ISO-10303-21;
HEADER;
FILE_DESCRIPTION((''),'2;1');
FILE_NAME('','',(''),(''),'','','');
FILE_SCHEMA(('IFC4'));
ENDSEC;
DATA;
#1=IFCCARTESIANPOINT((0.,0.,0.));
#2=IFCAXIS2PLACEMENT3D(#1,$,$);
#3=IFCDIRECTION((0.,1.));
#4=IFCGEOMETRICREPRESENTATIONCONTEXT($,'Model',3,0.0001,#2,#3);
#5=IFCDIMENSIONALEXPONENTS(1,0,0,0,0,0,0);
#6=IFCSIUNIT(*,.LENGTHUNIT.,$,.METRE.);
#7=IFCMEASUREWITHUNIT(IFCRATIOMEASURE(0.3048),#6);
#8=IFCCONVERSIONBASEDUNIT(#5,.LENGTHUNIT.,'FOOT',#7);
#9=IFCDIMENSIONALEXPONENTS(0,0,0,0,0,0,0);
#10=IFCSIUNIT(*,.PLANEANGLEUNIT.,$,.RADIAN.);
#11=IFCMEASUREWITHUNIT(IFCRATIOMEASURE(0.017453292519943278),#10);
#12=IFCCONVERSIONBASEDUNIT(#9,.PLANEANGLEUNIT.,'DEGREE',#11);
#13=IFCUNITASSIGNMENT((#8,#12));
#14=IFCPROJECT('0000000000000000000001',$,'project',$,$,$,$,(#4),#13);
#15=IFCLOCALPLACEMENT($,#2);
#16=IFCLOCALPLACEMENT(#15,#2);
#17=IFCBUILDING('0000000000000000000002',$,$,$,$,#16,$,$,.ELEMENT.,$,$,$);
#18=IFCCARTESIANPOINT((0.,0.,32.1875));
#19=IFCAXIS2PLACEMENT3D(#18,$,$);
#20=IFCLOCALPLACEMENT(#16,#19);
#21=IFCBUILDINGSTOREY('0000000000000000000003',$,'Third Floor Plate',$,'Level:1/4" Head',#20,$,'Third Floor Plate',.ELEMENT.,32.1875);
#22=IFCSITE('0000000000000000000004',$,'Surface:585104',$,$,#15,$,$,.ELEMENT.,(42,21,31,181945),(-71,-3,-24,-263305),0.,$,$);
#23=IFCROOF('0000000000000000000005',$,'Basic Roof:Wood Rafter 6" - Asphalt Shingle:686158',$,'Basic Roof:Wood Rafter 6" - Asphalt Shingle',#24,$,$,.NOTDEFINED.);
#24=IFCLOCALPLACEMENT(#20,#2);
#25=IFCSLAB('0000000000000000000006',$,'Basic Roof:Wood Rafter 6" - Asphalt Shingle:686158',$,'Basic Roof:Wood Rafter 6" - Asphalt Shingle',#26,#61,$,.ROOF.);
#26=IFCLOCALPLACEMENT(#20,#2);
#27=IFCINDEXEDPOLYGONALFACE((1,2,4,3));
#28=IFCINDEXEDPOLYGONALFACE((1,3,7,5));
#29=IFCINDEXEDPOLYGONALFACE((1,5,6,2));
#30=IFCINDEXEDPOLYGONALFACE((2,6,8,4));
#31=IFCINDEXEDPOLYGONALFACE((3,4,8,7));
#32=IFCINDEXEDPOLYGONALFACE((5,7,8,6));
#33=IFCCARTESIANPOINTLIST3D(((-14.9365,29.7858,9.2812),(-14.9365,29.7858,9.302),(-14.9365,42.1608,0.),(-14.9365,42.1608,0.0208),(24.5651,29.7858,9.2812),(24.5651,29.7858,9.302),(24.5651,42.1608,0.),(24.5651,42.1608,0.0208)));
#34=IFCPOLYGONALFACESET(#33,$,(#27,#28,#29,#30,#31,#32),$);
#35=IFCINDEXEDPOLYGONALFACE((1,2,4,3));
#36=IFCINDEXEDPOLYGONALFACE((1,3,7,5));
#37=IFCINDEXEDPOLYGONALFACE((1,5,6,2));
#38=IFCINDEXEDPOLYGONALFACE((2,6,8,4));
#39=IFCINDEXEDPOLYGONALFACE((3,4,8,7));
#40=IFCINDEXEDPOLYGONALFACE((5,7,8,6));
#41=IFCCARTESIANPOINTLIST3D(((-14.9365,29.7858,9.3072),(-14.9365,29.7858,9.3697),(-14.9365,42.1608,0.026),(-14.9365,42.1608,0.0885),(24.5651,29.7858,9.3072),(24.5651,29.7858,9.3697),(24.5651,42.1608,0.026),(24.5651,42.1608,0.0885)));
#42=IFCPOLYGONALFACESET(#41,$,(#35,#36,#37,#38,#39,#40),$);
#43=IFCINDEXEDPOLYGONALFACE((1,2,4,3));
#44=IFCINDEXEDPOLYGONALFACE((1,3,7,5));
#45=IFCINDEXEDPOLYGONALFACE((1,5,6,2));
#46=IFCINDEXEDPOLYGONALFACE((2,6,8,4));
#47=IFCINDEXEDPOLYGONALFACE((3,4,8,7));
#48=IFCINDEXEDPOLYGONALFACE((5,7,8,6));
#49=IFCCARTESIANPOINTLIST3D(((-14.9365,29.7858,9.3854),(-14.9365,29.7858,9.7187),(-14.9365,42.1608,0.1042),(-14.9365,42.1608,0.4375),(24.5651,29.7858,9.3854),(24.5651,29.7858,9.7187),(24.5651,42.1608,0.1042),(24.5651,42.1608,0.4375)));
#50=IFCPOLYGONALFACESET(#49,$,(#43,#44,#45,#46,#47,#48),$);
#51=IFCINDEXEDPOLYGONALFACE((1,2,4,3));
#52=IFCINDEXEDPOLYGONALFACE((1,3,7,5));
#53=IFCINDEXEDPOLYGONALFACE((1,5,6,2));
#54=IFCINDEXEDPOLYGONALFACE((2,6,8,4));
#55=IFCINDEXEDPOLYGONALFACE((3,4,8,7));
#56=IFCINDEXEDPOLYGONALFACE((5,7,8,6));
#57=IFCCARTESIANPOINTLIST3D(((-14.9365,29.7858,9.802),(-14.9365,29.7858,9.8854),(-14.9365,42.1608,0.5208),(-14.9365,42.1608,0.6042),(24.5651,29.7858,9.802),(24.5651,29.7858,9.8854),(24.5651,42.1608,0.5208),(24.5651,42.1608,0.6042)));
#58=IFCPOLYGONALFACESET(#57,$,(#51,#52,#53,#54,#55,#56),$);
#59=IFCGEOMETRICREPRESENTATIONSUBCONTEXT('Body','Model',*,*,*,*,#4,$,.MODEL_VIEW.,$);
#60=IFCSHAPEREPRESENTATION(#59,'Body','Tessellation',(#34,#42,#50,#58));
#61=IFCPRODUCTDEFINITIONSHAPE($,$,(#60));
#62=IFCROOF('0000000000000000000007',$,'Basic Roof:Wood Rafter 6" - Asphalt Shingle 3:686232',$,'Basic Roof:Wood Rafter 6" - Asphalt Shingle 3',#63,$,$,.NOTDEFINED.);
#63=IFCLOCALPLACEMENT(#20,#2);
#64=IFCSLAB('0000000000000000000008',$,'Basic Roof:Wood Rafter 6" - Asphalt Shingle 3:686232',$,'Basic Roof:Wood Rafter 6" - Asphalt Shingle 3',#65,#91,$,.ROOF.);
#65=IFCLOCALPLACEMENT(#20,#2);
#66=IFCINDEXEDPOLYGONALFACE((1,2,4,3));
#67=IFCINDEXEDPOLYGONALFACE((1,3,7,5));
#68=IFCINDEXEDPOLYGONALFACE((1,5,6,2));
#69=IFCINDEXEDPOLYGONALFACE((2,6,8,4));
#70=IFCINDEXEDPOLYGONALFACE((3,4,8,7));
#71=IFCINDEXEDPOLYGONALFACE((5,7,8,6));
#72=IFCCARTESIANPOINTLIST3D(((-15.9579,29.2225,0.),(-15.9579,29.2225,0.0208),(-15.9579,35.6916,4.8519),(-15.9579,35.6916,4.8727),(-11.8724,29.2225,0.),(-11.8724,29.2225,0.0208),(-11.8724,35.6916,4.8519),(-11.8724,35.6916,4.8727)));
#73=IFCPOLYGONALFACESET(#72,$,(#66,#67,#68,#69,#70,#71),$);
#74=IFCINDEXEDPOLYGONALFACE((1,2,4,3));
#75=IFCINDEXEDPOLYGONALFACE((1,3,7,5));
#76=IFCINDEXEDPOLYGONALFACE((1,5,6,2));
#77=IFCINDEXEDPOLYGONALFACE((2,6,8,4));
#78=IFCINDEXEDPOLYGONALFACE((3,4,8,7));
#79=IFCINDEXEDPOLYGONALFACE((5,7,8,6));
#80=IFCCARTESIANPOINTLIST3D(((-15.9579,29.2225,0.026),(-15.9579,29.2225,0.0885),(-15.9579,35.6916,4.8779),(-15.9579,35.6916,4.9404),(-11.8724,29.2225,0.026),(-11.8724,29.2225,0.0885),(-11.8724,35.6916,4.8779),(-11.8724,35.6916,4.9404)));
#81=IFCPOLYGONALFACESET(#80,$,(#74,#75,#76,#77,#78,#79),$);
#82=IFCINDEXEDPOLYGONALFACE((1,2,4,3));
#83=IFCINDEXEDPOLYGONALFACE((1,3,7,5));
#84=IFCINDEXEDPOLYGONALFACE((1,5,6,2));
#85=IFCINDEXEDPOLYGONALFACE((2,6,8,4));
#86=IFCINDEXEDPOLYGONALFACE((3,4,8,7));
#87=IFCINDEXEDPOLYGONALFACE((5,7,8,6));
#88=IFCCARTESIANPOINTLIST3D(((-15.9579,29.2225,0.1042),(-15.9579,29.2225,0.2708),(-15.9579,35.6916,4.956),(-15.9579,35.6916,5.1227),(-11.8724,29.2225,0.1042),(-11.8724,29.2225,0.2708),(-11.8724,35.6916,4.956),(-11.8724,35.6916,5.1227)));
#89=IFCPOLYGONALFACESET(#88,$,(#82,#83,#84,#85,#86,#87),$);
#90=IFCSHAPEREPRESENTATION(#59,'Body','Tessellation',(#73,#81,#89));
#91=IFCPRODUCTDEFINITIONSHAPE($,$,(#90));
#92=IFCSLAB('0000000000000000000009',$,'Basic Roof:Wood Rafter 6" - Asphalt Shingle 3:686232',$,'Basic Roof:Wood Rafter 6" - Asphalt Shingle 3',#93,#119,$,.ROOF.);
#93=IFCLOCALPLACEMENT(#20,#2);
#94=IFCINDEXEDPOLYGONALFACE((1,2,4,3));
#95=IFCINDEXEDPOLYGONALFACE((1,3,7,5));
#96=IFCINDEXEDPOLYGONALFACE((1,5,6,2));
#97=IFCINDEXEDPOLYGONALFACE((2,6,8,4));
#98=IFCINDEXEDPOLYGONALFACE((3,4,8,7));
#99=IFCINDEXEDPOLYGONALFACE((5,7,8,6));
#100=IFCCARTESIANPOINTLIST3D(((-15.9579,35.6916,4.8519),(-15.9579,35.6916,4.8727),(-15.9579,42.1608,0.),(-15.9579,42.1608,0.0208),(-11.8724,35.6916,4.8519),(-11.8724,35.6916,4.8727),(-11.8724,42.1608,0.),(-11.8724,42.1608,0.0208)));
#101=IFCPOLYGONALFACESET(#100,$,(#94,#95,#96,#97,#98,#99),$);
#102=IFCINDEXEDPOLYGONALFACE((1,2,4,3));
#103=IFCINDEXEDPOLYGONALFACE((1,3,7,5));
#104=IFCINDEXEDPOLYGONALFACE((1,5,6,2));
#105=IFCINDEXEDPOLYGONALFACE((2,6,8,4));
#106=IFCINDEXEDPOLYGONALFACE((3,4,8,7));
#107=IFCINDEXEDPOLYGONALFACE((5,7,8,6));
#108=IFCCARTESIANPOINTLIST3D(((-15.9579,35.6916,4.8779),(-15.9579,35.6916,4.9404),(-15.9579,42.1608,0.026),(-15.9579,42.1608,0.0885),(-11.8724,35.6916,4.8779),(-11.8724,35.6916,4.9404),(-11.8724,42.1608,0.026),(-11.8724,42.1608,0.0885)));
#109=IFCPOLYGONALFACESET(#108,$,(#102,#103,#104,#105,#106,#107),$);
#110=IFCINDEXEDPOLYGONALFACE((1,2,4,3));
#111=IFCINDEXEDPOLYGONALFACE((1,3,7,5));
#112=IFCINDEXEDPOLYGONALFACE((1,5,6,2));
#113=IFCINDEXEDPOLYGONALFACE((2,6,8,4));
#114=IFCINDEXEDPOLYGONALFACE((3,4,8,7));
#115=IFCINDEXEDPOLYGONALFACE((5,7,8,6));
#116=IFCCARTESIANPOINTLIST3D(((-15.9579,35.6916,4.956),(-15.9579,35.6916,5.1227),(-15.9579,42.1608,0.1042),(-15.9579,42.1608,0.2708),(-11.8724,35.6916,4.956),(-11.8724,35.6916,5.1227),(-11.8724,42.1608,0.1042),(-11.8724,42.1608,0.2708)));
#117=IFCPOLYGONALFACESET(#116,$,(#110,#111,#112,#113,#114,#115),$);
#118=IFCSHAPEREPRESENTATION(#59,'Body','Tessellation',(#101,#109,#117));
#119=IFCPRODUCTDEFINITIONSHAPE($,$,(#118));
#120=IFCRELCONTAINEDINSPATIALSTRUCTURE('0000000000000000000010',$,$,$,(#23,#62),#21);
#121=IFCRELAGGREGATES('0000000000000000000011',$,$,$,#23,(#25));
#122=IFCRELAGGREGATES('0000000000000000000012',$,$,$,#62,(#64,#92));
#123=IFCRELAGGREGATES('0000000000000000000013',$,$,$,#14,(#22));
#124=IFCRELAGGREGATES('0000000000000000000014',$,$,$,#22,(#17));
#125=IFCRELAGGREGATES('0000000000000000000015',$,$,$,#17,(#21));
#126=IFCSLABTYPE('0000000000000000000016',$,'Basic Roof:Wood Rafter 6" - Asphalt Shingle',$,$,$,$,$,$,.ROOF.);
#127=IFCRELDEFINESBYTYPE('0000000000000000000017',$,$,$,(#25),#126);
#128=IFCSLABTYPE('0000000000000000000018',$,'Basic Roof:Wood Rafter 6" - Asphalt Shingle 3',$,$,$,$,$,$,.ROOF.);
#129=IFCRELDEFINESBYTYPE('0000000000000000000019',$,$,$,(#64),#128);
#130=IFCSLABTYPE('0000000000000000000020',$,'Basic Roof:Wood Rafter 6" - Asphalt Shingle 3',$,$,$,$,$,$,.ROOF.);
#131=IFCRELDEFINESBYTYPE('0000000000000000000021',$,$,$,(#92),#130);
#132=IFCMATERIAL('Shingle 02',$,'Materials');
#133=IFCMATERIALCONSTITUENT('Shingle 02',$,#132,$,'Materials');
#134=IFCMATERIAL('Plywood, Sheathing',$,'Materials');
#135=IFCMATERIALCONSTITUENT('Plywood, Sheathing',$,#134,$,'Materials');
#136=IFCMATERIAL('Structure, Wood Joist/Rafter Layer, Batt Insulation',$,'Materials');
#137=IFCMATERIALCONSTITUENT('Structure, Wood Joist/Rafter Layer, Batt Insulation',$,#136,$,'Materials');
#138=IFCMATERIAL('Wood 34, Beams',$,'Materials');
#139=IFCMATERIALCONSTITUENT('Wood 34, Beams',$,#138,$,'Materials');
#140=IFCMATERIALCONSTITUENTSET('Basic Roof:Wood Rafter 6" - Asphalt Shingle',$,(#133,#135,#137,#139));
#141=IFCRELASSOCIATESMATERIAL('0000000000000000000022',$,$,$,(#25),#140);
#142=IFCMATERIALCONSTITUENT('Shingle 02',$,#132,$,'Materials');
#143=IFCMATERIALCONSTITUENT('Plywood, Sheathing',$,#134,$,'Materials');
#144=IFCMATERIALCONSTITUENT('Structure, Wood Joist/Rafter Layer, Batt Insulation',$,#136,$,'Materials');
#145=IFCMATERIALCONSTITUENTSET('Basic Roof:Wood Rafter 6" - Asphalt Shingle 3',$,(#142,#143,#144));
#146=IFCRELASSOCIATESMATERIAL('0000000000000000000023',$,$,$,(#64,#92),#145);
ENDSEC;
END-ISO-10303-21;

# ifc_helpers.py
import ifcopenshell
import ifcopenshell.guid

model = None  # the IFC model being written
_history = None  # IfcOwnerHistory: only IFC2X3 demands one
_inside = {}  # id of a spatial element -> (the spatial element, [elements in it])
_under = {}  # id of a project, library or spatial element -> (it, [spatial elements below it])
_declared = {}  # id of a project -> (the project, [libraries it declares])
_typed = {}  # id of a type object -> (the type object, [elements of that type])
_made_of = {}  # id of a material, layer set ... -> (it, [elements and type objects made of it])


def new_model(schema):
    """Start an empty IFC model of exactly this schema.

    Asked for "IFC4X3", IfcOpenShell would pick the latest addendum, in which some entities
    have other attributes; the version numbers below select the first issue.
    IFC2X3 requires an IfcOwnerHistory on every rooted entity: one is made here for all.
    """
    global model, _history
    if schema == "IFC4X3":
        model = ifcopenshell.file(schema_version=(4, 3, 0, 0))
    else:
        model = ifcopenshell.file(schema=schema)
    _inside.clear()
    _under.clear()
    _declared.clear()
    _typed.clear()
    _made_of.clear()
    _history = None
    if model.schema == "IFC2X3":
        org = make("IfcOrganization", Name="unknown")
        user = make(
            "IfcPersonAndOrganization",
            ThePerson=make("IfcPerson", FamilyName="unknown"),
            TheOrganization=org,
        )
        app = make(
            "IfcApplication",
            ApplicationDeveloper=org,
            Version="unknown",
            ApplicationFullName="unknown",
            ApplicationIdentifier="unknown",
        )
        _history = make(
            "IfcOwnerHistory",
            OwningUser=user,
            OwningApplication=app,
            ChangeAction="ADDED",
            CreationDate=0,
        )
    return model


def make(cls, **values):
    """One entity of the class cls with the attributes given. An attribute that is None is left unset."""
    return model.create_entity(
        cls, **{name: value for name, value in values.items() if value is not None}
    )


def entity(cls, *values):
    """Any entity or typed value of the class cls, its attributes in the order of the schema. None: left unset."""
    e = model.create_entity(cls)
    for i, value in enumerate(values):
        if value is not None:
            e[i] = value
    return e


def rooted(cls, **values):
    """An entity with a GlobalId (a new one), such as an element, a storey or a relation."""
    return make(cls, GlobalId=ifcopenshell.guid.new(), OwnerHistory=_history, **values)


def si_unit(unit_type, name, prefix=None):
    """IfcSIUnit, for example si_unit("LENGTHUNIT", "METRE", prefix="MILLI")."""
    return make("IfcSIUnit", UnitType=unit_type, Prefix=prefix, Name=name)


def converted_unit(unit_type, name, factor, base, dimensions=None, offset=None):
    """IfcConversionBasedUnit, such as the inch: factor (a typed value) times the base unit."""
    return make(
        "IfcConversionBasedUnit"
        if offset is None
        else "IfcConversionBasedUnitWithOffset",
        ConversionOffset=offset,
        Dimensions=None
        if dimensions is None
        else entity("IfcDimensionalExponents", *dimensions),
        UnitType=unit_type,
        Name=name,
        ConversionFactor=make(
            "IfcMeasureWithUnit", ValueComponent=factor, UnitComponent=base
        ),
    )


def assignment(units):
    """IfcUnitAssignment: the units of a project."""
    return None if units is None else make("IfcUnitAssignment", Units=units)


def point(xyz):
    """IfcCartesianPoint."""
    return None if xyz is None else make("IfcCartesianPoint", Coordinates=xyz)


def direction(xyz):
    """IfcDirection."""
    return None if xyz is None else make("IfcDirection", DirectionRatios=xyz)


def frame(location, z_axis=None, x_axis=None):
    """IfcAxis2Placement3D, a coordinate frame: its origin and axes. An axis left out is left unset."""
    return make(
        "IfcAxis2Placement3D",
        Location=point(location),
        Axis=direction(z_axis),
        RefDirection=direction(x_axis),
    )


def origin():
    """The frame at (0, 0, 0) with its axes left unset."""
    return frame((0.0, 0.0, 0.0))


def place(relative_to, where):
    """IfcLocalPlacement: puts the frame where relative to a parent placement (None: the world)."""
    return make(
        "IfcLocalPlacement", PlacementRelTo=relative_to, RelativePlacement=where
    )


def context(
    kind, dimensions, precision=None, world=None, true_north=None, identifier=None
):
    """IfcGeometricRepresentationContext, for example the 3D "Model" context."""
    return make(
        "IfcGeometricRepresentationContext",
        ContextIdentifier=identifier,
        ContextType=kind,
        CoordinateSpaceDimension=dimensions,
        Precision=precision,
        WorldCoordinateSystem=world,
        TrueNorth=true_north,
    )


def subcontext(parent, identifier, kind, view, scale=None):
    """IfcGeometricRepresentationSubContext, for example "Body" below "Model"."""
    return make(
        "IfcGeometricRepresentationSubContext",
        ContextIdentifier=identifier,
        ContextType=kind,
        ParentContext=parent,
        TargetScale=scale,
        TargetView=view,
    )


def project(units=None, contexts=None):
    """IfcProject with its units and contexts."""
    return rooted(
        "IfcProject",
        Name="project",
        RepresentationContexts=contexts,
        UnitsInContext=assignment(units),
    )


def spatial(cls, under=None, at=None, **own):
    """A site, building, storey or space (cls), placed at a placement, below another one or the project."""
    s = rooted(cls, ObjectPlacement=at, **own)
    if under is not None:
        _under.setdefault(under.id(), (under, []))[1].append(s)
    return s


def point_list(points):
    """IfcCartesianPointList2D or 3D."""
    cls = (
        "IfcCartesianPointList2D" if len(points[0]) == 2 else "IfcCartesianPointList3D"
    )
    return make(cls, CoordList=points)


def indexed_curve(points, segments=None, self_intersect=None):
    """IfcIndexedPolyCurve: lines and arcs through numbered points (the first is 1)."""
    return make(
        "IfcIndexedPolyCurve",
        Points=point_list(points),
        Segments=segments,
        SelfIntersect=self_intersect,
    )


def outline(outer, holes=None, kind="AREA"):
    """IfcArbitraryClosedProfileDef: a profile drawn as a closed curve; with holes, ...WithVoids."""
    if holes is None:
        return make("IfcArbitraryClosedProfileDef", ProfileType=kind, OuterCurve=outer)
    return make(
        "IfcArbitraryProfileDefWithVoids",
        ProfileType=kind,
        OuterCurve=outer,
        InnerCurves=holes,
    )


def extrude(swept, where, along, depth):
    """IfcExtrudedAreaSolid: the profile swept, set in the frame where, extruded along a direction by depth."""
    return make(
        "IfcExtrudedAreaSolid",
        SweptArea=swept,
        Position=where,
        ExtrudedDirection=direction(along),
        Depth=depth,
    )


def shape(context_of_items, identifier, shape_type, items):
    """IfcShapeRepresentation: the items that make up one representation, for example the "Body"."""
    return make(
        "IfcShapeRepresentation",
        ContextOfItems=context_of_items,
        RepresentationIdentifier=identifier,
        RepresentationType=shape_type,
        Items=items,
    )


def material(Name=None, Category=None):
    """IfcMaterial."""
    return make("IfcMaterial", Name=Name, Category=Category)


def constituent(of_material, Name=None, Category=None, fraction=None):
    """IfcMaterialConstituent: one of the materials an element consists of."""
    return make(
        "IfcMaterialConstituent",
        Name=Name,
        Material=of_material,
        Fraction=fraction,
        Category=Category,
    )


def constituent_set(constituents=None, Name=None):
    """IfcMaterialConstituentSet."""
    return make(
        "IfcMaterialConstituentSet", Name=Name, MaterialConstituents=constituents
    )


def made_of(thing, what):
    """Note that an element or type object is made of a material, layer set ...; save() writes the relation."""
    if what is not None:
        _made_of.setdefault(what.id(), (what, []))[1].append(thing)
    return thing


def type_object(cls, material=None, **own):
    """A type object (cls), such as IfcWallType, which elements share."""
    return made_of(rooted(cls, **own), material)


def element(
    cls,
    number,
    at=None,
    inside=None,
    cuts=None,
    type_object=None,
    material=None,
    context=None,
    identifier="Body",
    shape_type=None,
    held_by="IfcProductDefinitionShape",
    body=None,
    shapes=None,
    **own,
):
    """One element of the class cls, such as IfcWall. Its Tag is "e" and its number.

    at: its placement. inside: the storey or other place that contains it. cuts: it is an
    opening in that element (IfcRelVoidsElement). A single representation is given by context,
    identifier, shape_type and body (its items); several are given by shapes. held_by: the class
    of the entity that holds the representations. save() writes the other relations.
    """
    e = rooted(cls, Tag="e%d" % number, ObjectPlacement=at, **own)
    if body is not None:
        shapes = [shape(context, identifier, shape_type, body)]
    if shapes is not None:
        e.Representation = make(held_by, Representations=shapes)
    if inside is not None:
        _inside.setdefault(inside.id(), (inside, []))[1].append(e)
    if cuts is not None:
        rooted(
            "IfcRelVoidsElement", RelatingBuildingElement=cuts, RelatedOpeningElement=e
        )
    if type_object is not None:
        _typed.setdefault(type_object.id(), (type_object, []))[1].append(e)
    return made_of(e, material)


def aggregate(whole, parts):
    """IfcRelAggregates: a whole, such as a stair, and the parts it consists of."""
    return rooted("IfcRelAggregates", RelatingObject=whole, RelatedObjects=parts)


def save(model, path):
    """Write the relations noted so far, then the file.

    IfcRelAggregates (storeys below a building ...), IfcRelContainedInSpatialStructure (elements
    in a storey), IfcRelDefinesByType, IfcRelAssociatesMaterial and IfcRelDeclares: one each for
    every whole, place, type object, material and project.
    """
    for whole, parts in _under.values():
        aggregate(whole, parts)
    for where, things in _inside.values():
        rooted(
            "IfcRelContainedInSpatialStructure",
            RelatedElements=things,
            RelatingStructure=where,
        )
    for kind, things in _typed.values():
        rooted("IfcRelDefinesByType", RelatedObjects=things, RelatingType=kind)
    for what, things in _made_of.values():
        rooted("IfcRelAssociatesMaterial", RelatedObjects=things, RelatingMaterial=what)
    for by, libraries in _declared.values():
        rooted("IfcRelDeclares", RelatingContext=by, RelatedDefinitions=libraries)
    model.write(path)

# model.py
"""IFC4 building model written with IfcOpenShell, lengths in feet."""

from ifc_helpers import new_model, entity, si_unit, converted_unit, direction, frame, origin, place, context, subcontext, project, spatial, indexed_curve, outline, extrude, material, constituent, constituent_set, type_object, element, aggregate, save


model = new_model("IFC4")

# Units and contexts
model_context = context("Model", 3, precision=0.0001, world=origin(), true_north=direction((0.0, 1.0)))
body_context = subcontext(model_context, "Body", "Model", "MODEL_VIEW")
ifc_project = project(units=[converted_unit("LENGTHUNIT", "FOOT", entity("IfcRatioMeasure", 0.3048), si_unit("LENGTHUNIT", "METRE"), dimensions=[1, 0, 0, 0, 0, 0, 0]), converted_unit("PLANEANGLEUNIT", "DEGREE", entity("IfcRatioMeasure", 0.017453292519943278), si_unit("PLANEANGLEUNIT", "RADIAN"), dimensions=[0, 0, 0, 0, 0, 0, 0])], contexts=[model_context])

# Site, building, storey
site_placement = place(None, origin())
site = spatial("IfcSite", under=ifc_project, at=site_placement, Name="Surface:585104", CompositionType="ELEMENT", RefLatitude=(42, 21, 31, 181945), RefLongitude=(-71, -3, -24, -263305), RefElevation=0.0)
building_placement = place(site_placement, origin())
building = spatial("IfcBuilding", under=site, at=building_placement, CompositionType="ELEMENT")
storey_placement = place(building_placement, frame((0.0, 0.0, 32.1875)))
storey = spatial("IfcBuildingStorey", under=building, at=storey_placement, Name="Third Floor Plate", ObjectType="Level:1/4\" Head", LongName="Third Floor Plate", CompositionType="ELEMENT", Elevation=32.1875)

# Roofs, slabs
ifc_material_1 = material(Name="Shingle 02", Category="Materials")
ifc_constituent_1 = constituent(ifc_material_1, Name="Shingle 02", Category="Materials")
ifc_material_2 = material(Name="Plywood, Sheathing", Category="Materials")
ifc_constituent_2 = constituent(ifc_material_2, Name="Plywood, Sheathing", Category="Materials")
ifc_material_3 = material(Name="Structure, Wood Joist/Rafter Layer, Batt Insulation", Category="Materials")
ifc_constituent_3 = constituent(ifc_material_3, Name="Structure, Wood Joist/Rafter Layer, Batt Insulation", Category="Materials")
ifc_material_4 = material(Name="Wood 34, Beams", Category="Materials")
ifc_constituent_4 = constituent(ifc_material_4, Name="Wood 34, Beams", Category="Materials")
ifc_constituent_set_1 = constituent_set(constituents=[ifc_constituent_1, ifc_constituent_2, ifc_constituent_3, ifc_constituent_4], Name="Basic Roof:Wood Rafter 6\" - Asphalt Shingle")
ifc_constituent_5 = constituent(ifc_material_1, Name="Shingle 02", Category="Materials")
ifc_constituent_6 = constituent(ifc_material_2, Name="Plywood, Sheathing", Category="Materials")
ifc_constituent_7 = constituent(ifc_material_3, Name="Structure, Wood Joist/Rafter Layer, Batt Insulation", Category="Materials")
ifc_constituent_set_2 = constituent_set(constituents=[ifc_constituent_5, ifc_constituent_6, ifc_constituent_7], Name="Basic Roof:Wood Rafter 6\" - Asphalt Shingle 3")
roof_1_placement = place(storey_placement, frame((-14.9365, 17.4109, 0.0)))
roof_1 = element("IfcRoof", 1, at=roof_1_placement, inside=storey, Name="Basic Roof:Wood Rafter 6\" - Asphalt Shingle:686158", ObjectType="Basic Roof:Wood Rafter 6\" - Asphalt Shingle", PredefinedType="NOTDEFINED")
slab_type_1 = type_object("IfcSlabType", Name="Basic Roof:Wood Rafter 6\" - Asphalt Shingle", PredefinedType="ROOF")
slab_1_placement = place(roof_1_placement, origin())
slab_1 = element("IfcSlab", 2, at=slab_1_placement, type_object=slab_type_1, material=ifc_constituent_set_1, Name="Basic Roof:Wood Rafter 6\" - Asphalt Shingle:686158", ObjectType="Basic Roof:Wood Rafter 6\" - Asphalt Shingle", PredefinedType="ROOF", context=body_context, shape_type="SweptSolid", body=[
    extrude(outline(indexed_curve([(-19.7508, 7.7343), (-19.7508, -7.7343), (19.7508, -7.7343), (19.7508, 7.7343), (-19.7508, 7.7343)], self_intersect=False)), frame((19.7508, 18.5624, 4.6406), z_axis=(0.0, 0.6, 0.8), x_axis=(1.0, 0.0, 0.0)), (0.0, -0.6, 0.8), 0.0208),
    extrude(outline(indexed_curve([(-19.7508, 7.7343), (-19.7508, -7.7343), (19.7508, -7.7343), (19.7508, 7.7343), (-19.7508, 7.7343)], self_intersect=False)), frame((19.7508, 18.5624, 4.6666), z_axis=(0.0, 0.6, 0.8), x_axis=(1.0, 0.0, 0.0)), (0.0, -0.6, 0.8), 0.0625),
    extrude(outline(indexed_curve([(-19.7508, 7.7343), (-19.7508, -7.7343), (19.7508, -7.7343), (19.7508, 7.7343), (-19.7508, 7.7343)], self_intersect=False)), frame((19.7508, 18.5624, 4.7448), z_axis=(0.0, 0.6, 0.8), x_axis=(1.0, 0.0, 0.0)), (0.0, -0.6, 0.8), 0.3333),
    extrude(outline(indexed_curve([(-19.7508, 7.7343), (-19.7508, -7.7343), (19.7508, -7.7343), (19.7508, 7.7343), (-19.7508, 7.7343)], self_intersect=False)), frame((19.7508, 18.5624, 5.1614), z_axis=(0.0, 0.6, 0.8), x_axis=(1.0, 0.0, 0.0)), (0.0, -0.6, 0.8), 0.0833),
])
aggregate(roof_1, [slab_1])
roof_2_placement = place(storey_placement, frame((-15.9579, 29.2225, 0.0)))
roof_2 = element("IfcRoof", 3, at=roof_2_placement, inside=storey, Name="Basic Roof:Wood Rafter 6\" - Asphalt Shingle 3:686232", ObjectType="Basic Roof:Wood Rafter 6\" - Asphalt Shingle 3", PredefinedType="NOTDEFINED")
slab_type_2 = type_object("IfcSlabType", Name="Basic Roof:Wood Rafter 6\" - Asphalt Shingle 3", PredefinedType="ROOF")
slab_2_placement = place(roof_2_placement, origin())
slab_2 = element("IfcSlab", 4, at=slab_2_placement, type_object=slab_type_2, material=ifc_constituent_set_2, Name="Basic Roof:Wood Rafter 6\" - Asphalt Shingle 3:686232", ObjectType="Basic Roof:Wood Rafter 6\" - Asphalt Shingle 3", PredefinedType="ROOF", context=body_context, shape_type="SweptSolid", body=[
    extrude(outline(indexed_curve([(2.0427, -4.0432), (2.0427, 4.0432), (-2.0427, 4.0432), (-2.0427, -4.0432), (2.0427, -4.0432)], self_intersect=False)), frame((2.0427, 3.2346, 2.4259), z_axis=(0.0, -0.6, 0.8), x_axis=(1.0, 0.0, 0.0)), (0.0, 0.6, 0.8), 0.0208),
    extrude(outline(indexed_curve([(2.0427, -4.0432), (2.0427, 4.0432), (-2.0427, 4.0432), (-2.0427, -4.0432), (2.0427, -4.0432)], self_intersect=False)), frame((2.0427, 3.2346, 2.452), z_axis=(0.0, -0.6, 0.8), x_axis=(1.0, 0.0, 0.0)), (0.0, 0.6, 0.8), 0.0625),
    extrude(outline(indexed_curve([(2.0427, -4.0432), (2.0427, 4.0432), (-2.0427, 4.0432), (-2.0427, -4.0432), (2.0427, -4.0432)], self_intersect=False)), frame((2.0427, 3.2346, 2.5301), z_axis=(0.0, -0.6, 0.8), x_axis=(1.0, 0.0, 0.0)), (0.0, 0.6, 0.8), 0.1667),
])
slab_type_3 = type_object("IfcSlabType", Name="Basic Roof:Wood Rafter 6\" - Asphalt Shingle 3", PredefinedType="ROOF")
slab_3_placement = place(roof_2_placement, origin())
slab_3 = element("IfcSlab", 5, at=slab_3_placement, type_object=slab_type_3, material=ifc_constituent_set_2, Name="Basic Roof:Wood Rafter 6\" - Asphalt Shingle 3:686232", ObjectType="Basic Roof:Wood Rafter 6\" - Asphalt Shingle 3", PredefinedType="ROOF", context=body_context, shape_type="SweptSolid", body=[
    extrude(outline(indexed_curve([(-2.0427, -4.0432), (2.0427, -4.0432), (2.0427, 4.0432), (-2.0427, 4.0432), (-2.0427, -4.0432)], self_intersect=False)), frame((2.0427, 9.7037, 2.4259), z_axis=(0.0, 0.6, 0.8), x_axis=(1.0, 0.0, 0.0)), (0.0, -0.6, 0.8), 0.0208),
    extrude(outline(indexed_curve([(-2.0427, -4.0432), (2.0427, -4.0432), (2.0427, 4.0432), (-2.0427, 4.0432), (-2.0427, -4.0432)], self_intersect=False)), frame((2.0427, 9.7037, 2.452), z_axis=(0.0, 0.6, 0.8), x_axis=(1.0, 0.0, 0.0)), (0.0, -0.6, 0.8), 0.0625),
    extrude(outline(indexed_curve([(-2.0427, -4.0432), (2.0427, -4.0432), (2.0427, 4.0432), (-2.0427, 4.0432), (-2.0427, -4.0432)], self_intersect=False)), frame((2.0427, 9.7037, 2.5301), z_axis=(0.0, 0.6, 0.8), x_axis=(1.0, 0.0, 0.0)), (0.0, -0.6, 0.8), 0.1667),
])
aggregate(roof_2, [slab_2, slab_3])

save(model, "model.ifc")
